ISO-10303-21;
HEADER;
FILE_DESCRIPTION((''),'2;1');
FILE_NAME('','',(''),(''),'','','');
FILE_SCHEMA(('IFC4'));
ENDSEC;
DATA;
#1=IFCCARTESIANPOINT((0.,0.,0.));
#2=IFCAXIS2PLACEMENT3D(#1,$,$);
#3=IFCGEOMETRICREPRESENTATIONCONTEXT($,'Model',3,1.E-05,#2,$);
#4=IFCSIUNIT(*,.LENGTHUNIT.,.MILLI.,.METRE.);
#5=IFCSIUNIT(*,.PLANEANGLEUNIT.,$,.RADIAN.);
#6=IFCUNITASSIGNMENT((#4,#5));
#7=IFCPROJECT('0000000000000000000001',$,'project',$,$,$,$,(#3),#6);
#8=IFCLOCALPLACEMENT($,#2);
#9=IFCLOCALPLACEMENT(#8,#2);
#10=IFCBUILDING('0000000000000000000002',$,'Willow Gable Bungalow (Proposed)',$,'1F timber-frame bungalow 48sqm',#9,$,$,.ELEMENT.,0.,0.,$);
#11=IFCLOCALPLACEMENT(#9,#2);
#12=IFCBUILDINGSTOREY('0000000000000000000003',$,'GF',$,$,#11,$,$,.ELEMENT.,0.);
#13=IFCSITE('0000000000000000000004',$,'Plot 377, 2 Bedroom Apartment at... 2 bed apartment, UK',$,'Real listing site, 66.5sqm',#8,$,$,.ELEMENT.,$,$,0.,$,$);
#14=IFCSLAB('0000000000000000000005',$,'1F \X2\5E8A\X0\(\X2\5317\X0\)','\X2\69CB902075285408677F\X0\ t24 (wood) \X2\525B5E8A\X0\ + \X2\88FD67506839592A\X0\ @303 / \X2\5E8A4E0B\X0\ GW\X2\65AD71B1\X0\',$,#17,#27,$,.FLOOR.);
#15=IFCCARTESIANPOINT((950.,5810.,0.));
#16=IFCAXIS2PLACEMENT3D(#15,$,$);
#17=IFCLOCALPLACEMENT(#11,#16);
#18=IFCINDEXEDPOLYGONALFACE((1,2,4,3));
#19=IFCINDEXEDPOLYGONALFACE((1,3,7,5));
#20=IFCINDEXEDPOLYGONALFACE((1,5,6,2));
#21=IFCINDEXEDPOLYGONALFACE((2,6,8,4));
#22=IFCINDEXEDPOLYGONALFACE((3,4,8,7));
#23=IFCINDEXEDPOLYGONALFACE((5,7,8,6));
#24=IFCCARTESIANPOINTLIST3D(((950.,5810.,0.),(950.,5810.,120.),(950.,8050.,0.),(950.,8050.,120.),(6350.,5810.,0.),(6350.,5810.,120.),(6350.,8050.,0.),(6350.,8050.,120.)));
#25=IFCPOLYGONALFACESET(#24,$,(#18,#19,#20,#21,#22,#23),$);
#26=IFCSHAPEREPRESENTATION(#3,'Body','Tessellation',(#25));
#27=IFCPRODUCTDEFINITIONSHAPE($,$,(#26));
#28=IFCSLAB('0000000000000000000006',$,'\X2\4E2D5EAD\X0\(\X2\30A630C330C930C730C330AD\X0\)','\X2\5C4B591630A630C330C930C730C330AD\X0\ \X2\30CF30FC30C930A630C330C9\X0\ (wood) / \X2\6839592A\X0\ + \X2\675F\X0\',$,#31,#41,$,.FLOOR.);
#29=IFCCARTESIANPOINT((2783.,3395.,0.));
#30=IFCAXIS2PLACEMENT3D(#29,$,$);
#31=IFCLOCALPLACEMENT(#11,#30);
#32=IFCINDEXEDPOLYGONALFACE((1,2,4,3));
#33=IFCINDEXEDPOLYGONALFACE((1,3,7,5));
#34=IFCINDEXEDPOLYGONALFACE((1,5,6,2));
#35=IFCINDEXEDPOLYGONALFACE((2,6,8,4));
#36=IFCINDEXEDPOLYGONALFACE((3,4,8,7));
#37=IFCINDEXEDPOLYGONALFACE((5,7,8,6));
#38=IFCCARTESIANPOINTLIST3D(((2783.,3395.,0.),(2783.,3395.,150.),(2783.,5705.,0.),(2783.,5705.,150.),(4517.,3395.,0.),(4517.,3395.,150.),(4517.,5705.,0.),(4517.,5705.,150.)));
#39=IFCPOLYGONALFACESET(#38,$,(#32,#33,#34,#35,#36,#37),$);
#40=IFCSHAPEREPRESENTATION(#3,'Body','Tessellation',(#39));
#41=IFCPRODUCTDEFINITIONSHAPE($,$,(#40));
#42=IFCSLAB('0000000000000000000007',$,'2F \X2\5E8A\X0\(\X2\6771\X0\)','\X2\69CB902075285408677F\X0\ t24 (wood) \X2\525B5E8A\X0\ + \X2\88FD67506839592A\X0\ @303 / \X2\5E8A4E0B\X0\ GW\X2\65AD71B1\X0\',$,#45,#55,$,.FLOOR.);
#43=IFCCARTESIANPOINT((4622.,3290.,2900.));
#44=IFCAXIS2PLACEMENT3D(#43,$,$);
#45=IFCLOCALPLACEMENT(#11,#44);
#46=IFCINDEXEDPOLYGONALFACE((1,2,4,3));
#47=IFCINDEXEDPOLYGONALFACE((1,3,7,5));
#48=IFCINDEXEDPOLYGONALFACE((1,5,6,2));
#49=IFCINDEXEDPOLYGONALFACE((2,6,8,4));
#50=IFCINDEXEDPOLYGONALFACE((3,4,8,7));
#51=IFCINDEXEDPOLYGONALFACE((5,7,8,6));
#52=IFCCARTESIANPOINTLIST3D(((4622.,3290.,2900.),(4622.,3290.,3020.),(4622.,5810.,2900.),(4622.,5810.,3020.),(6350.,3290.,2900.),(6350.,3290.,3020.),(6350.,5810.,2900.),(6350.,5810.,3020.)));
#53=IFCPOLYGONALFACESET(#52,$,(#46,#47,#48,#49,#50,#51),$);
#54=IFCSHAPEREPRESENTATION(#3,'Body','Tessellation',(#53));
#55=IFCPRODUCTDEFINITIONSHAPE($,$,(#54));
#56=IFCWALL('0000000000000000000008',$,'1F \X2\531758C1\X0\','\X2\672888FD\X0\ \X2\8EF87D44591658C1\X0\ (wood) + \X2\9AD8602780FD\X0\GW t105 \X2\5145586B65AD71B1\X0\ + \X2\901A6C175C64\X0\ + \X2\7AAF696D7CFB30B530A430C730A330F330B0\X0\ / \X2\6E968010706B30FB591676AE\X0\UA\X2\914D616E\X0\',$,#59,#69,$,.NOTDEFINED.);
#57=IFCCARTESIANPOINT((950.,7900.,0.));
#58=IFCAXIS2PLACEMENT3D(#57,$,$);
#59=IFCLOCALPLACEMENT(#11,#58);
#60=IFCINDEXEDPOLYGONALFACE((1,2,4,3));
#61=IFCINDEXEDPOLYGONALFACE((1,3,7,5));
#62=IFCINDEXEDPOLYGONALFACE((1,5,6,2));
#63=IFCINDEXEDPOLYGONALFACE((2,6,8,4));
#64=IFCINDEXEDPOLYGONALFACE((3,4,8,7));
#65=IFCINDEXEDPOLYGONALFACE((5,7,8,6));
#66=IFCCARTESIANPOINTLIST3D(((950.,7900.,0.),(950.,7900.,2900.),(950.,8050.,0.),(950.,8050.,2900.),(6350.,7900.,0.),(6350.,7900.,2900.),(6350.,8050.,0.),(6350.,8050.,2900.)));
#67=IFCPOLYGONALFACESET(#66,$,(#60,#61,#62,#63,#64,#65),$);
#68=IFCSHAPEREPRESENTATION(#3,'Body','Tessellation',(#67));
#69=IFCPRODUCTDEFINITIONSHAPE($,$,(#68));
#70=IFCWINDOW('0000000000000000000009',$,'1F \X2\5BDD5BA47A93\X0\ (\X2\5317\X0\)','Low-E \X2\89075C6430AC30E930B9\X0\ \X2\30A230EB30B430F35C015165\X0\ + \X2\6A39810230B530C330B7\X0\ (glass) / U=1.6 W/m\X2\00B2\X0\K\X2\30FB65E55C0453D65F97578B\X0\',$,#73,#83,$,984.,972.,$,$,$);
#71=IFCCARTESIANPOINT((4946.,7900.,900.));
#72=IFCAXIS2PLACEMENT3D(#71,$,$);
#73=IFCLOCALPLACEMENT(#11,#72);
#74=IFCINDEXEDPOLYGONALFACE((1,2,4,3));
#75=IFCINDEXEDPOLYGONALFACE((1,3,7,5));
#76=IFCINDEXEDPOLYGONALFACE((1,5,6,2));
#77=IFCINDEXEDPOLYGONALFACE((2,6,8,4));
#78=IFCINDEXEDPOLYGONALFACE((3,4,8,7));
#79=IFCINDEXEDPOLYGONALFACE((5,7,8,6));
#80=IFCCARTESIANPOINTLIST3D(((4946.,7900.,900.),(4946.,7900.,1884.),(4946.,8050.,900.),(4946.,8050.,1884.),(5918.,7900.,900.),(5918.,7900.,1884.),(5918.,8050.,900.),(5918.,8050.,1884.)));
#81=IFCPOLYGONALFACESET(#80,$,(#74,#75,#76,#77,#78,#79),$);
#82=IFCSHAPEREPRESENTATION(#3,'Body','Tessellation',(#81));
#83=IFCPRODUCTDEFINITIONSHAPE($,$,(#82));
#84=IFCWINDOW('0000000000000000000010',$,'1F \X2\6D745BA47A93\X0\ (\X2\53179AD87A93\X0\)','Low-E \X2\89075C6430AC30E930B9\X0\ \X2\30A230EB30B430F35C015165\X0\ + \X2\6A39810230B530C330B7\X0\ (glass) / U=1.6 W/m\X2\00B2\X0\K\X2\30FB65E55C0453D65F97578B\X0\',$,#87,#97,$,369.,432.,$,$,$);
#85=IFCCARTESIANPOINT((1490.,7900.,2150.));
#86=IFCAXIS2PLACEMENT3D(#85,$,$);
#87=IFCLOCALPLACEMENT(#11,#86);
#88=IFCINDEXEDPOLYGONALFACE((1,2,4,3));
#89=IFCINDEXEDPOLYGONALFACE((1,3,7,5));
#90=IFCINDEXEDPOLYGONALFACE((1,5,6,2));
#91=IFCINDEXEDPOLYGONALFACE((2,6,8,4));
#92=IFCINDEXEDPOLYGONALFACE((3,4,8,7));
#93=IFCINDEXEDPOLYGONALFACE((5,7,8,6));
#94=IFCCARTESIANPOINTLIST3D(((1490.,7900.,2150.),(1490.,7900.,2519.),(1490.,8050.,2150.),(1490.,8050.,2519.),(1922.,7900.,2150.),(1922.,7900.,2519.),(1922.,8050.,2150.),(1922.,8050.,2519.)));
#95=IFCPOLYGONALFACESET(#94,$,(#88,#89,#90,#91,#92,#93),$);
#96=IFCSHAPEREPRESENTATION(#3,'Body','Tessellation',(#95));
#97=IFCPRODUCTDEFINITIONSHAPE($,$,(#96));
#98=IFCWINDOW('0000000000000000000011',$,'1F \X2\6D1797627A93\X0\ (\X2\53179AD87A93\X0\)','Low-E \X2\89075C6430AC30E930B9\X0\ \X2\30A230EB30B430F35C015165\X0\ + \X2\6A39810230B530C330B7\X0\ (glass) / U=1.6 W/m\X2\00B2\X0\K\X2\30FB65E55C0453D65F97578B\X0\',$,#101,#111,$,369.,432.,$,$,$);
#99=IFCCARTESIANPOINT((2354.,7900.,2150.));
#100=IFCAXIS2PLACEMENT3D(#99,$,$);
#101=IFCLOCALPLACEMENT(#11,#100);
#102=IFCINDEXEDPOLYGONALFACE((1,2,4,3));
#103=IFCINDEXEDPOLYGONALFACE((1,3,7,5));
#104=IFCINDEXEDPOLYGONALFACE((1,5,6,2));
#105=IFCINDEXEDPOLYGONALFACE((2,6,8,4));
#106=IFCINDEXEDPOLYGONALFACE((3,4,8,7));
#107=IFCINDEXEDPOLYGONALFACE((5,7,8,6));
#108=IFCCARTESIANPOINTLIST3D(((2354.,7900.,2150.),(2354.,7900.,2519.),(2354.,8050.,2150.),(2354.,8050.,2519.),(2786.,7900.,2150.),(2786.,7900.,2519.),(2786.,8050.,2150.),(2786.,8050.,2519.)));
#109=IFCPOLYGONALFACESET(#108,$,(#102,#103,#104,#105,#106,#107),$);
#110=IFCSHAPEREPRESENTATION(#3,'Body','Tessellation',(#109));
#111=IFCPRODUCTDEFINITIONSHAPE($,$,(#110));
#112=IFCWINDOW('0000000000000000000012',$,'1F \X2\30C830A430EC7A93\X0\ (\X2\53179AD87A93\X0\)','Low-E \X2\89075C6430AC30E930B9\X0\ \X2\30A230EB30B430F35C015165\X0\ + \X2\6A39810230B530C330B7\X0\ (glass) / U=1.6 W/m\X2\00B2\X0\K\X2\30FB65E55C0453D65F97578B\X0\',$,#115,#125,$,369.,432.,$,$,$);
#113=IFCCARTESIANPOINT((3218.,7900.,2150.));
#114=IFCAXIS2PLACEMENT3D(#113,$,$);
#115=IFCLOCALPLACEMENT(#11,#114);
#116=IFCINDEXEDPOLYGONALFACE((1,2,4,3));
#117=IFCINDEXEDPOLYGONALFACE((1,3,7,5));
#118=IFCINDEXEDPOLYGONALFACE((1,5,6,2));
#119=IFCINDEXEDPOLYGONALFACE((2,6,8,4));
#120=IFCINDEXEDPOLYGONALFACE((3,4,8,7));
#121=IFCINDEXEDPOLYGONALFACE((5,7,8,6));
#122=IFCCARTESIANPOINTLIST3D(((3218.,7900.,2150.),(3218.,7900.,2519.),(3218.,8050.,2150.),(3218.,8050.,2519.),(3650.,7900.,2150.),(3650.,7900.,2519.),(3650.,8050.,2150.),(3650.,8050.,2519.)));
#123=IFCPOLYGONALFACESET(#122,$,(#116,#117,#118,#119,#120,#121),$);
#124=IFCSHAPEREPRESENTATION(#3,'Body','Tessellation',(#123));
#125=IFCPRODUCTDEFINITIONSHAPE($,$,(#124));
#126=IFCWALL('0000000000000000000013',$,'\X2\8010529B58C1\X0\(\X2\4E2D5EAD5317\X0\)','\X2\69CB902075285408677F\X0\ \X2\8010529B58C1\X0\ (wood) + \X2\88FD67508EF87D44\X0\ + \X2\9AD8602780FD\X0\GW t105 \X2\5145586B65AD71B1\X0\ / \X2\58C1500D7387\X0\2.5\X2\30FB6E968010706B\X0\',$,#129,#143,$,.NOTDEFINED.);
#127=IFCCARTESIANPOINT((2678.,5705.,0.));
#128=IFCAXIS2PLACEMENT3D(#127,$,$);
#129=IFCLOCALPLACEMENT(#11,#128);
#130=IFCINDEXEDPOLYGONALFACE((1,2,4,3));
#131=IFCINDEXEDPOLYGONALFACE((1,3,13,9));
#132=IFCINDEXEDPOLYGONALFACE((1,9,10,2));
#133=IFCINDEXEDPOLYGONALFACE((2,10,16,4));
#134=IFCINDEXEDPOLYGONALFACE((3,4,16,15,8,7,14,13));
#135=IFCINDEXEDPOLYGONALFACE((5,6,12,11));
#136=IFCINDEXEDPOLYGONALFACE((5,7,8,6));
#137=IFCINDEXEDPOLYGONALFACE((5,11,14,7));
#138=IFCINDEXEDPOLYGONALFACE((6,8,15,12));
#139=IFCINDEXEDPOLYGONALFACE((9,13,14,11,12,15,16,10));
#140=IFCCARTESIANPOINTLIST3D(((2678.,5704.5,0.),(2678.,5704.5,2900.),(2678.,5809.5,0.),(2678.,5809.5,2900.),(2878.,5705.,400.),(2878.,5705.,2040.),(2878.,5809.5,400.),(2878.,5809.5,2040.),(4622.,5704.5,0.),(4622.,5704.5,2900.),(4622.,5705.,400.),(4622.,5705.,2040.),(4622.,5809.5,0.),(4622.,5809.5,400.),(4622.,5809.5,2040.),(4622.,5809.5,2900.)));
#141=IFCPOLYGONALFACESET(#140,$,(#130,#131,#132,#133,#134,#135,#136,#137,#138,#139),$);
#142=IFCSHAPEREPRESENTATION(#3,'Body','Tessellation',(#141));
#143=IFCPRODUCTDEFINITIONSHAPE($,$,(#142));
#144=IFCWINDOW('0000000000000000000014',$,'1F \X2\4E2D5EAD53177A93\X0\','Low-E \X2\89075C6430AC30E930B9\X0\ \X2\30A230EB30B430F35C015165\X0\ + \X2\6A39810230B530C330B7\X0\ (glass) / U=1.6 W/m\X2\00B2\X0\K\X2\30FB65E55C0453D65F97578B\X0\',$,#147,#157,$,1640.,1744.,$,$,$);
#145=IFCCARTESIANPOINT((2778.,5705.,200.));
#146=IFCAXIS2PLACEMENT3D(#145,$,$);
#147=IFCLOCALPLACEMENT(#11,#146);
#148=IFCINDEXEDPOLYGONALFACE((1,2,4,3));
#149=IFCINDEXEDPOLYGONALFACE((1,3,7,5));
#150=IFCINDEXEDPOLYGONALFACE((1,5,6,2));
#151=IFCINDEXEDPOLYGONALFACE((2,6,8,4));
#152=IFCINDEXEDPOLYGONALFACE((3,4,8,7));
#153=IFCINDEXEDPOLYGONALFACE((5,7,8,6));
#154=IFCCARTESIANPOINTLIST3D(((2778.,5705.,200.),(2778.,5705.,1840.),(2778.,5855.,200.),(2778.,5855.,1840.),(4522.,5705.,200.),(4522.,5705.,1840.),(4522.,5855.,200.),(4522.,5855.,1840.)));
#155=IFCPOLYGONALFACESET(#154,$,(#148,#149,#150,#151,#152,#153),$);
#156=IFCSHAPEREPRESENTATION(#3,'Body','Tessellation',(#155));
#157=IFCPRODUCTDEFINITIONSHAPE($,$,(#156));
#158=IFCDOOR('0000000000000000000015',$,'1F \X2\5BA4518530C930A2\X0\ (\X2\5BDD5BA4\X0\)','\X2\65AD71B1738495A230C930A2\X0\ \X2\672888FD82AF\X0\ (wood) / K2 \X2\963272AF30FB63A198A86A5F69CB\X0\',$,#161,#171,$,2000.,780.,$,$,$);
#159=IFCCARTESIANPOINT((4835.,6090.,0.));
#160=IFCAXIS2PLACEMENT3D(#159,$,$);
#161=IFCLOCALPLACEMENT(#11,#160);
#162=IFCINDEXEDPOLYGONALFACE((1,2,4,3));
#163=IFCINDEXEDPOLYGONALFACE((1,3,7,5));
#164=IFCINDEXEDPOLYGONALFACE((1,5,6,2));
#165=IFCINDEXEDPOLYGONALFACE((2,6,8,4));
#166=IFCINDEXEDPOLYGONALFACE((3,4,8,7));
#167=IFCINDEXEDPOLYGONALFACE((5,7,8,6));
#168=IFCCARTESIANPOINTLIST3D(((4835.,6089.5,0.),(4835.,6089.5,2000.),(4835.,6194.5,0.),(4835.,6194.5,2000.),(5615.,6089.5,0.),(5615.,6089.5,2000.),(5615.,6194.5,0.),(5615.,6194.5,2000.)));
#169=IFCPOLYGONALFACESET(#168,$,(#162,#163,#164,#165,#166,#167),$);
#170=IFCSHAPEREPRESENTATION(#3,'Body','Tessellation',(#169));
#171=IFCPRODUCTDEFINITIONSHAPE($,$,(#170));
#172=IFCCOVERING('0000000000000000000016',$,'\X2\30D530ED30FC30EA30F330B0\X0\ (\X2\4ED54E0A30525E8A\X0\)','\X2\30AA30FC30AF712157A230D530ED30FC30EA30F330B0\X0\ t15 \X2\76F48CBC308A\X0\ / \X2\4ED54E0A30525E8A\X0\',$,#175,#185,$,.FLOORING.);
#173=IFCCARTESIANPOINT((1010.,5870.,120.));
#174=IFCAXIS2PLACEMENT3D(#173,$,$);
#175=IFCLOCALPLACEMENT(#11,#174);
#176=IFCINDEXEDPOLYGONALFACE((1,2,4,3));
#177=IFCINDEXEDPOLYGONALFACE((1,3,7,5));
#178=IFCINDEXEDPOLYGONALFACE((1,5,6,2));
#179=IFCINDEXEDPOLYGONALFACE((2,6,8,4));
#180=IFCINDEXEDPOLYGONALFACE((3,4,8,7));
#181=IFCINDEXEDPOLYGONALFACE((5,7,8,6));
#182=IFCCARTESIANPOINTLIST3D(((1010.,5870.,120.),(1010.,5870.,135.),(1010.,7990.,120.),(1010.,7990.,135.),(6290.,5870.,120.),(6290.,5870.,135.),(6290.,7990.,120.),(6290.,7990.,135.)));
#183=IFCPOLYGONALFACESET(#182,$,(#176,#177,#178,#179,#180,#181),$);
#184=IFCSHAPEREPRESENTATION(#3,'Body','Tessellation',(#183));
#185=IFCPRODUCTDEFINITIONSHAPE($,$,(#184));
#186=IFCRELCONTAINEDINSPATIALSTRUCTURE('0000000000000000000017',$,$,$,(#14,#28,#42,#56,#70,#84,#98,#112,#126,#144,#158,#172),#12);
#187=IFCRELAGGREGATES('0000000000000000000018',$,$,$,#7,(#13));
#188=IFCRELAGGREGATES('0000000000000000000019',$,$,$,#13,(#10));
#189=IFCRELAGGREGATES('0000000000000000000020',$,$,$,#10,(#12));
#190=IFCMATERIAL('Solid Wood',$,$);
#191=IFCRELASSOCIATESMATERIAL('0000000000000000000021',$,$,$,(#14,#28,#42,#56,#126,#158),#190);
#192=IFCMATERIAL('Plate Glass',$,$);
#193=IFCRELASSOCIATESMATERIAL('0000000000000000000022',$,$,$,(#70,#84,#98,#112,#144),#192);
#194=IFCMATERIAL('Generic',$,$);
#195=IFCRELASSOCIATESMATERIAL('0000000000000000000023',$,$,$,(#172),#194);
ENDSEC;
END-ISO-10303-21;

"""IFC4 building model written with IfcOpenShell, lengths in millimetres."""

from ifc_helpers import new_model, si_unit, frame, frame_2d, origin, place, context, project, spatial, rectangle, extrude, material, element, fill, save


model = new_model("IFC4")

# Units and contexts
model_context = context("Model", 3, precision=1e-05, world=origin())
ifc_project = project(units=[si_unit("LENGTHUNIT", "METRE", prefix="MILLI"), si_unit("PLANEANGLEUNIT", "RADIAN")], contexts=[model_context])

# Site, building, storey
site_placement = place(None, origin())
site = spatial("IfcSite", under=ifc_project, at=site_placement, Name="Plot 377, 2 Bedroom Apartment at... 2 bed apartment, UK", ObjectType="Real listing site, 66.5sqm", CompositionType="ELEMENT", RefElevation=0.0)
building_placement = place(site_placement, origin())
building = spatial("IfcBuilding", under=site, at=building_placement, Name="Willow Gable Bungalow (Proposed)", ObjectType="1F timber-frame bungalow 48sqm", CompositionType="ELEMENT", ElevationOfRefHeight=0.0, ElevationOfTerrain=0.0)
storey_placement = place(building_placement, origin())
storey = spatial("IfcBuildingStorey", under=building, at=storey_placement, Name="GF", CompositionType="ELEMENT", Elevation=0.0)

# Slabs
ifc_material_1 = material(Name="Solid Wood")
slab_1_placement = place(storey_placement, frame((950.0, 5810.0, 0.0)))
element("IfcSlab", 1, at=slab_1_placement, inside=storey, material=ifc_material_1, Name="1F 床(北)", Description="構造用合板 t24 (wood) 剛床 + 製材根太 @303 / 床下 GW断熱", PredefinedType="FLOOR", context=model_context, shape_type="SweptSolid", body=[
    extrude(rectangle(XDim=5400.0, YDim=2240.0, at=frame_2d((2700.0, 1120.0))), frame((950.0, 5810.0, 0.0)), (0.0, 0.0, 1.0), 120.0),
])
slab_2_placement = place(storey_placement, frame((2783.0, 3395.0, 0.0)))
element("IfcSlab", 2, at=slab_2_placement, inside=storey, material=ifc_material_1, Name="中庭(ウッドデッキ)", Description="屋外ウッドデッキ ハードウッド (wood) / 根太 + 束", PredefinedType="FLOOR", context=model_context, shape_type="SweptSolid", body=[
    extrude(rectangle(XDim=1734.0, YDim=2310.0, at=frame_2d((867.0, 1155.0))), frame((2783.0, 3395.0, 0.0)), (0.0, 0.0, 1.0), 150.0),
])
slab_3_placement = place(storey_placement, frame((4622.0, 3290.0, 2900.0)))
element("IfcSlab", 3, at=slab_3_placement, inside=storey, material=ifc_material_1, Name="2F 床(東)", Description="構造用合板 t24 (wood) 剛床 + 製材根太 @303 / 床下 GW断熱", PredefinedType="FLOOR", context=model_context, shape_type="SweptSolid", body=[
    extrude(rectangle(XDim=1728.0, YDim=2520.0, at=frame_2d((864.0, 1260.0))), frame((4622.0, 3290.0, 2900.0)), (0.0, 0.0, 1.0), 120.0),
])

# Wall, openings, windows
wall_1_placement = place(storey_placement, frame((950.0, 7900.0, 0.0)))
wall_1 = element("IfcWall", 4, at=wall_1_placement, inside=storey, material=ifc_material_1, Name="1F 北壁", Description="木製 軸組外壁 (wood) + 高性能GW t105 充填断熱 + 通気層 + 窯業系サイディング / 準耐火・外皮UA配慮", PredefinedType="NOTDEFINED", context=model_context, shape_type="SweptSolid", body=[
    extrude(rectangle(XDim=5400.0, YDim=150.0, at=frame_2d((2700.0, 75.0))), frame((950.0, 7900.0, 0.0)), (0.0, 0.0, 1.0), 2900.0),
])
opening_1_placement = place(storey_placement, frame((4946.0, 7900.0, 900.0)))
opening_1 = element("IfcOpeningElement", 5, at=opening_1_placement, cuts=wall_1, PredefinedType="NOTDEFINED", context=model_context, shape_type="SweptSolid", body=[
    extrude(rectangle(XDim=972.0, YDim=150.0, at=frame_2d((486.0, 75.0))), frame((4946.0, 7900.0, 900.0)), (0.0, 0.0, 1.0), 984.0),
])
opening_2_placement = place(storey_placement, frame((1490.0, 7900.0, 2150.0)))
opening_2 = element("IfcOpeningElement", 6, at=opening_2_placement, cuts=wall_1, PredefinedType="NOTDEFINED", context=model_context, shape_type="SweptSolid", body=[
    extrude(rectangle(XDim=432.0, YDim=150.0, at=frame_2d((216.0, 75.0))), frame((1490.0, 7900.0, 2150.0)), (0.0, 0.0, 1.0), 369.0),
])
opening_3_placement = place(storey_placement, frame((2354.0, 7900.0, 2150.0)))
opening_3 = element("IfcOpeningElement", 7, at=opening_3_placement, cuts=wall_1, PredefinedType="NOTDEFINED", context=model_context, shape_type="SweptSolid", body=[
    extrude(rectangle(XDim=432.0, YDim=150.0, at=frame_2d((216.0, 75.0))), frame((2354.0, 7900.0, 2150.0)), (0.0, 0.0, 1.0), 369.0),
])
opening_4_placement = place(storey_placement, frame((3218.0, 7900.0, 2150.0)))
opening_4 = element("IfcOpeningElement", 8, at=opening_4_placement, cuts=wall_1, PredefinedType="NOTDEFINED", context=model_context, shape_type="SweptSolid", body=[
    extrude(rectangle(XDim=432.0, YDim=150.0, at=frame_2d((216.0, 75.0))), frame((3218.0, 7900.0, 2150.0)), (0.0, 0.0, 1.0), 369.0),
])
ifc_material_2 = material(Name="Plate Glass")
window_1_placement = place(storey_placement, frame((4946.0, 7900.0, 900.0)))
window_1 = element("IfcWindow", 9, at=window_1_placement, inside=storey, material=ifc_material_2, Name="1F 寝室窓 (北)", Description="Low-E 複層ガラス アルゴン封入 + 樹脂サッシ (glass) / U=1.6 W/m²K・日射取得型", OverallHeight=984.0, OverallWidth=972.0, context=model_context, shape_type="SweptSolid", body=[
    extrude(rectangle(XDim=972.0, YDim=150.0, at=frame_2d((486.0, 75.0))), frame((4946.0, 7900.0, 900.0)), (0.0, 0.0, 1.0), 984.0),
])
fill(opening_1, window_1)
window_2_placement = place(storey_placement, frame((1490.0, 7900.0, 2150.0)))
window_2 = element("IfcWindow", 10, at=window_2_placement, inside=storey, material=ifc_material_2, Name="1F 浴室窓 (北高窓)", Description="Low-E 複層ガラス アルゴン封入 + 樹脂サッシ (glass) / U=1.6 W/m²K・日射取得型", OverallHeight=369.0, OverallWidth=432.0, context=model_context, shape_type="SweptSolid", body=[
    extrude(rectangle(XDim=432.0, YDim=150.0, at=frame_2d((216.0, 75.0))), frame((1490.0, 7900.0, 2150.0)), (0.0, 0.0, 1.0), 369.0),
])
fill(opening_2, window_2)
window_3_placement = place(storey_placement, frame((2354.0, 7900.0, 2150.0)))
window_3 = element("IfcWindow", 11, at=window_3_placement, inside=storey, material=ifc_material_2, Name="1F 洗面窓 (北高窓)", Description="Low-E 複層ガラス アルゴン封入 + 樹脂サッシ (glass) / U=1.6 W/m²K・日射取得型", OverallHeight=369.0, OverallWidth=432.0, context=model_context, shape_type="SweptSolid", body=[
    extrude(rectangle(XDim=432.0, YDim=150.0, at=frame_2d((216.0, 75.0))), frame((2354.0, 7900.0, 2150.0)), (0.0, 0.0, 1.0), 369.0),
])
fill(opening_3, window_3)
window_4_placement = place(storey_placement, frame((3218.0, 7900.0, 2150.0)))
window_4 = element("IfcWindow", 12, at=window_4_placement, inside=storey, material=ifc_material_2, Name="1F トイレ窓 (北高窓)", Description="Low-E 複層ガラス アルゴン封入 + 樹脂サッシ (glass) / U=1.6 W/m²K・日射取得型", OverallHeight=369.0, OverallWidth=432.0, context=model_context, shape_type="SweptSolid", body=[
    extrude(rectangle(XDim=432.0, YDim=150.0, at=frame_2d((216.0, 75.0))), frame((3218.0, 7900.0, 2150.0)), (0.0, 0.0, 1.0), 369.0),
])
fill(opening_4, window_4)

# Wall, opening, window
wall_2_placement = place(storey_placement, frame((2678.0, 5705.0, 0.0)))
wall_2 = element("IfcWall", 13, at=wall_2_placement, inside=storey, material=ifc_material_1, Name="耐力壁(中庭北)", Description="構造用合板 耐力壁 (wood) + 製材軸組 + 高性能GW t105 充填断熱 / 壁倍率2.5・準耐火", PredefinedType="NOTDEFINED", context=model_context, shape_type="SweptSolid", body=[
    extrude(rectangle(XDim=1944.0, YDim=105.0, at=frame_2d((972.0, 52.0))), frame((2678.0, 5705.0, 0.0)), (0.0, 0.0, 1.0), 2900.0),
])
opening_5_placement = place(storey_placement, frame((2778.0, 5705.0, 200.0)))
opening_5 = element("IfcOpeningElement", 14, at=opening_5_placement, cuts=wall_2, PredefinedType="NOTDEFINED", context=model_context, shape_type="SweptSolid", body=[
    extrude(rectangle(XDim=1744.0, YDim=150.0, at=frame_2d((872.0, 75.0))), frame((2778.0, 5705.0, 200.0)), (0.0, 0.0, 1.0), 1640.0),
])
window_5_placement = place(storey_placement, frame((2778.0, 5705.0, 200.0)))
window_5 = element("IfcWindow", 15, at=window_5_placement, inside=storey, material=ifc_material_2, Name="1F 中庭北窓", Description="Low-E 複層ガラス アルゴン封入 + 樹脂サッシ (glass) / U=1.6 W/m²K・日射取得型", OverallHeight=1640.0, OverallWidth=1744.0, context=model_context, shape_type="SweptSolid", body=[
    extrude(rectangle(XDim=1744.0, YDim=150.0, at=frame_2d((872.0, 75.0))), frame((2778.0, 5705.0, 200.0)), (0.0, 0.0, 1.0), 1640.0),
])
fill(opening_5, window_5)

# Door
door_1_placement = place(storey_placement, frame((4835.0, 6090.0, 0.0)))
element("IfcDoor", 16, at=door_1_placement, inside=storey, material=ifc_material_1, Name="1F 室内ドア (寝室)", Description="断熱玄関ドア 木製芯 (wood) / K2 防犯・採風機構", OverallHeight=2000.0, OverallWidth=780.0, context=model_context, shape_type="SweptSolid", body=[
    extrude(rectangle(XDim=780.0, YDim=105.0, at=frame_2d((390.0, 52.0))), frame((4835.0, 6090.0, 0.0)), (0.0, 0.0, 1.0), 2000.0),
])

# Covering
ifc_material_3 = material(Name="Generic")
covering_1_placement = place(storey_placement, frame((1010.0, 5870.0, 120.0)))
element("IfcCovering", 17, at=covering_1_placement, inside=storey, material=ifc_material_3, Name="フローリング (仕上げ床)", Description="オーク無垢フローリング t15 直貼り / 仕上げ床", PredefinedType="FLOORING", context=model_context, shape_type="SweptSolid", body=[
    extrude(rectangle(XDim=5280.0, YDim=2120.0, at=frame_2d((2640.0, 1060.0))), frame((1010.0, 5870.0, 120.0)), (0.0, 0.0, 1.0), 15.0),
])

save(model, "model.ifc")
